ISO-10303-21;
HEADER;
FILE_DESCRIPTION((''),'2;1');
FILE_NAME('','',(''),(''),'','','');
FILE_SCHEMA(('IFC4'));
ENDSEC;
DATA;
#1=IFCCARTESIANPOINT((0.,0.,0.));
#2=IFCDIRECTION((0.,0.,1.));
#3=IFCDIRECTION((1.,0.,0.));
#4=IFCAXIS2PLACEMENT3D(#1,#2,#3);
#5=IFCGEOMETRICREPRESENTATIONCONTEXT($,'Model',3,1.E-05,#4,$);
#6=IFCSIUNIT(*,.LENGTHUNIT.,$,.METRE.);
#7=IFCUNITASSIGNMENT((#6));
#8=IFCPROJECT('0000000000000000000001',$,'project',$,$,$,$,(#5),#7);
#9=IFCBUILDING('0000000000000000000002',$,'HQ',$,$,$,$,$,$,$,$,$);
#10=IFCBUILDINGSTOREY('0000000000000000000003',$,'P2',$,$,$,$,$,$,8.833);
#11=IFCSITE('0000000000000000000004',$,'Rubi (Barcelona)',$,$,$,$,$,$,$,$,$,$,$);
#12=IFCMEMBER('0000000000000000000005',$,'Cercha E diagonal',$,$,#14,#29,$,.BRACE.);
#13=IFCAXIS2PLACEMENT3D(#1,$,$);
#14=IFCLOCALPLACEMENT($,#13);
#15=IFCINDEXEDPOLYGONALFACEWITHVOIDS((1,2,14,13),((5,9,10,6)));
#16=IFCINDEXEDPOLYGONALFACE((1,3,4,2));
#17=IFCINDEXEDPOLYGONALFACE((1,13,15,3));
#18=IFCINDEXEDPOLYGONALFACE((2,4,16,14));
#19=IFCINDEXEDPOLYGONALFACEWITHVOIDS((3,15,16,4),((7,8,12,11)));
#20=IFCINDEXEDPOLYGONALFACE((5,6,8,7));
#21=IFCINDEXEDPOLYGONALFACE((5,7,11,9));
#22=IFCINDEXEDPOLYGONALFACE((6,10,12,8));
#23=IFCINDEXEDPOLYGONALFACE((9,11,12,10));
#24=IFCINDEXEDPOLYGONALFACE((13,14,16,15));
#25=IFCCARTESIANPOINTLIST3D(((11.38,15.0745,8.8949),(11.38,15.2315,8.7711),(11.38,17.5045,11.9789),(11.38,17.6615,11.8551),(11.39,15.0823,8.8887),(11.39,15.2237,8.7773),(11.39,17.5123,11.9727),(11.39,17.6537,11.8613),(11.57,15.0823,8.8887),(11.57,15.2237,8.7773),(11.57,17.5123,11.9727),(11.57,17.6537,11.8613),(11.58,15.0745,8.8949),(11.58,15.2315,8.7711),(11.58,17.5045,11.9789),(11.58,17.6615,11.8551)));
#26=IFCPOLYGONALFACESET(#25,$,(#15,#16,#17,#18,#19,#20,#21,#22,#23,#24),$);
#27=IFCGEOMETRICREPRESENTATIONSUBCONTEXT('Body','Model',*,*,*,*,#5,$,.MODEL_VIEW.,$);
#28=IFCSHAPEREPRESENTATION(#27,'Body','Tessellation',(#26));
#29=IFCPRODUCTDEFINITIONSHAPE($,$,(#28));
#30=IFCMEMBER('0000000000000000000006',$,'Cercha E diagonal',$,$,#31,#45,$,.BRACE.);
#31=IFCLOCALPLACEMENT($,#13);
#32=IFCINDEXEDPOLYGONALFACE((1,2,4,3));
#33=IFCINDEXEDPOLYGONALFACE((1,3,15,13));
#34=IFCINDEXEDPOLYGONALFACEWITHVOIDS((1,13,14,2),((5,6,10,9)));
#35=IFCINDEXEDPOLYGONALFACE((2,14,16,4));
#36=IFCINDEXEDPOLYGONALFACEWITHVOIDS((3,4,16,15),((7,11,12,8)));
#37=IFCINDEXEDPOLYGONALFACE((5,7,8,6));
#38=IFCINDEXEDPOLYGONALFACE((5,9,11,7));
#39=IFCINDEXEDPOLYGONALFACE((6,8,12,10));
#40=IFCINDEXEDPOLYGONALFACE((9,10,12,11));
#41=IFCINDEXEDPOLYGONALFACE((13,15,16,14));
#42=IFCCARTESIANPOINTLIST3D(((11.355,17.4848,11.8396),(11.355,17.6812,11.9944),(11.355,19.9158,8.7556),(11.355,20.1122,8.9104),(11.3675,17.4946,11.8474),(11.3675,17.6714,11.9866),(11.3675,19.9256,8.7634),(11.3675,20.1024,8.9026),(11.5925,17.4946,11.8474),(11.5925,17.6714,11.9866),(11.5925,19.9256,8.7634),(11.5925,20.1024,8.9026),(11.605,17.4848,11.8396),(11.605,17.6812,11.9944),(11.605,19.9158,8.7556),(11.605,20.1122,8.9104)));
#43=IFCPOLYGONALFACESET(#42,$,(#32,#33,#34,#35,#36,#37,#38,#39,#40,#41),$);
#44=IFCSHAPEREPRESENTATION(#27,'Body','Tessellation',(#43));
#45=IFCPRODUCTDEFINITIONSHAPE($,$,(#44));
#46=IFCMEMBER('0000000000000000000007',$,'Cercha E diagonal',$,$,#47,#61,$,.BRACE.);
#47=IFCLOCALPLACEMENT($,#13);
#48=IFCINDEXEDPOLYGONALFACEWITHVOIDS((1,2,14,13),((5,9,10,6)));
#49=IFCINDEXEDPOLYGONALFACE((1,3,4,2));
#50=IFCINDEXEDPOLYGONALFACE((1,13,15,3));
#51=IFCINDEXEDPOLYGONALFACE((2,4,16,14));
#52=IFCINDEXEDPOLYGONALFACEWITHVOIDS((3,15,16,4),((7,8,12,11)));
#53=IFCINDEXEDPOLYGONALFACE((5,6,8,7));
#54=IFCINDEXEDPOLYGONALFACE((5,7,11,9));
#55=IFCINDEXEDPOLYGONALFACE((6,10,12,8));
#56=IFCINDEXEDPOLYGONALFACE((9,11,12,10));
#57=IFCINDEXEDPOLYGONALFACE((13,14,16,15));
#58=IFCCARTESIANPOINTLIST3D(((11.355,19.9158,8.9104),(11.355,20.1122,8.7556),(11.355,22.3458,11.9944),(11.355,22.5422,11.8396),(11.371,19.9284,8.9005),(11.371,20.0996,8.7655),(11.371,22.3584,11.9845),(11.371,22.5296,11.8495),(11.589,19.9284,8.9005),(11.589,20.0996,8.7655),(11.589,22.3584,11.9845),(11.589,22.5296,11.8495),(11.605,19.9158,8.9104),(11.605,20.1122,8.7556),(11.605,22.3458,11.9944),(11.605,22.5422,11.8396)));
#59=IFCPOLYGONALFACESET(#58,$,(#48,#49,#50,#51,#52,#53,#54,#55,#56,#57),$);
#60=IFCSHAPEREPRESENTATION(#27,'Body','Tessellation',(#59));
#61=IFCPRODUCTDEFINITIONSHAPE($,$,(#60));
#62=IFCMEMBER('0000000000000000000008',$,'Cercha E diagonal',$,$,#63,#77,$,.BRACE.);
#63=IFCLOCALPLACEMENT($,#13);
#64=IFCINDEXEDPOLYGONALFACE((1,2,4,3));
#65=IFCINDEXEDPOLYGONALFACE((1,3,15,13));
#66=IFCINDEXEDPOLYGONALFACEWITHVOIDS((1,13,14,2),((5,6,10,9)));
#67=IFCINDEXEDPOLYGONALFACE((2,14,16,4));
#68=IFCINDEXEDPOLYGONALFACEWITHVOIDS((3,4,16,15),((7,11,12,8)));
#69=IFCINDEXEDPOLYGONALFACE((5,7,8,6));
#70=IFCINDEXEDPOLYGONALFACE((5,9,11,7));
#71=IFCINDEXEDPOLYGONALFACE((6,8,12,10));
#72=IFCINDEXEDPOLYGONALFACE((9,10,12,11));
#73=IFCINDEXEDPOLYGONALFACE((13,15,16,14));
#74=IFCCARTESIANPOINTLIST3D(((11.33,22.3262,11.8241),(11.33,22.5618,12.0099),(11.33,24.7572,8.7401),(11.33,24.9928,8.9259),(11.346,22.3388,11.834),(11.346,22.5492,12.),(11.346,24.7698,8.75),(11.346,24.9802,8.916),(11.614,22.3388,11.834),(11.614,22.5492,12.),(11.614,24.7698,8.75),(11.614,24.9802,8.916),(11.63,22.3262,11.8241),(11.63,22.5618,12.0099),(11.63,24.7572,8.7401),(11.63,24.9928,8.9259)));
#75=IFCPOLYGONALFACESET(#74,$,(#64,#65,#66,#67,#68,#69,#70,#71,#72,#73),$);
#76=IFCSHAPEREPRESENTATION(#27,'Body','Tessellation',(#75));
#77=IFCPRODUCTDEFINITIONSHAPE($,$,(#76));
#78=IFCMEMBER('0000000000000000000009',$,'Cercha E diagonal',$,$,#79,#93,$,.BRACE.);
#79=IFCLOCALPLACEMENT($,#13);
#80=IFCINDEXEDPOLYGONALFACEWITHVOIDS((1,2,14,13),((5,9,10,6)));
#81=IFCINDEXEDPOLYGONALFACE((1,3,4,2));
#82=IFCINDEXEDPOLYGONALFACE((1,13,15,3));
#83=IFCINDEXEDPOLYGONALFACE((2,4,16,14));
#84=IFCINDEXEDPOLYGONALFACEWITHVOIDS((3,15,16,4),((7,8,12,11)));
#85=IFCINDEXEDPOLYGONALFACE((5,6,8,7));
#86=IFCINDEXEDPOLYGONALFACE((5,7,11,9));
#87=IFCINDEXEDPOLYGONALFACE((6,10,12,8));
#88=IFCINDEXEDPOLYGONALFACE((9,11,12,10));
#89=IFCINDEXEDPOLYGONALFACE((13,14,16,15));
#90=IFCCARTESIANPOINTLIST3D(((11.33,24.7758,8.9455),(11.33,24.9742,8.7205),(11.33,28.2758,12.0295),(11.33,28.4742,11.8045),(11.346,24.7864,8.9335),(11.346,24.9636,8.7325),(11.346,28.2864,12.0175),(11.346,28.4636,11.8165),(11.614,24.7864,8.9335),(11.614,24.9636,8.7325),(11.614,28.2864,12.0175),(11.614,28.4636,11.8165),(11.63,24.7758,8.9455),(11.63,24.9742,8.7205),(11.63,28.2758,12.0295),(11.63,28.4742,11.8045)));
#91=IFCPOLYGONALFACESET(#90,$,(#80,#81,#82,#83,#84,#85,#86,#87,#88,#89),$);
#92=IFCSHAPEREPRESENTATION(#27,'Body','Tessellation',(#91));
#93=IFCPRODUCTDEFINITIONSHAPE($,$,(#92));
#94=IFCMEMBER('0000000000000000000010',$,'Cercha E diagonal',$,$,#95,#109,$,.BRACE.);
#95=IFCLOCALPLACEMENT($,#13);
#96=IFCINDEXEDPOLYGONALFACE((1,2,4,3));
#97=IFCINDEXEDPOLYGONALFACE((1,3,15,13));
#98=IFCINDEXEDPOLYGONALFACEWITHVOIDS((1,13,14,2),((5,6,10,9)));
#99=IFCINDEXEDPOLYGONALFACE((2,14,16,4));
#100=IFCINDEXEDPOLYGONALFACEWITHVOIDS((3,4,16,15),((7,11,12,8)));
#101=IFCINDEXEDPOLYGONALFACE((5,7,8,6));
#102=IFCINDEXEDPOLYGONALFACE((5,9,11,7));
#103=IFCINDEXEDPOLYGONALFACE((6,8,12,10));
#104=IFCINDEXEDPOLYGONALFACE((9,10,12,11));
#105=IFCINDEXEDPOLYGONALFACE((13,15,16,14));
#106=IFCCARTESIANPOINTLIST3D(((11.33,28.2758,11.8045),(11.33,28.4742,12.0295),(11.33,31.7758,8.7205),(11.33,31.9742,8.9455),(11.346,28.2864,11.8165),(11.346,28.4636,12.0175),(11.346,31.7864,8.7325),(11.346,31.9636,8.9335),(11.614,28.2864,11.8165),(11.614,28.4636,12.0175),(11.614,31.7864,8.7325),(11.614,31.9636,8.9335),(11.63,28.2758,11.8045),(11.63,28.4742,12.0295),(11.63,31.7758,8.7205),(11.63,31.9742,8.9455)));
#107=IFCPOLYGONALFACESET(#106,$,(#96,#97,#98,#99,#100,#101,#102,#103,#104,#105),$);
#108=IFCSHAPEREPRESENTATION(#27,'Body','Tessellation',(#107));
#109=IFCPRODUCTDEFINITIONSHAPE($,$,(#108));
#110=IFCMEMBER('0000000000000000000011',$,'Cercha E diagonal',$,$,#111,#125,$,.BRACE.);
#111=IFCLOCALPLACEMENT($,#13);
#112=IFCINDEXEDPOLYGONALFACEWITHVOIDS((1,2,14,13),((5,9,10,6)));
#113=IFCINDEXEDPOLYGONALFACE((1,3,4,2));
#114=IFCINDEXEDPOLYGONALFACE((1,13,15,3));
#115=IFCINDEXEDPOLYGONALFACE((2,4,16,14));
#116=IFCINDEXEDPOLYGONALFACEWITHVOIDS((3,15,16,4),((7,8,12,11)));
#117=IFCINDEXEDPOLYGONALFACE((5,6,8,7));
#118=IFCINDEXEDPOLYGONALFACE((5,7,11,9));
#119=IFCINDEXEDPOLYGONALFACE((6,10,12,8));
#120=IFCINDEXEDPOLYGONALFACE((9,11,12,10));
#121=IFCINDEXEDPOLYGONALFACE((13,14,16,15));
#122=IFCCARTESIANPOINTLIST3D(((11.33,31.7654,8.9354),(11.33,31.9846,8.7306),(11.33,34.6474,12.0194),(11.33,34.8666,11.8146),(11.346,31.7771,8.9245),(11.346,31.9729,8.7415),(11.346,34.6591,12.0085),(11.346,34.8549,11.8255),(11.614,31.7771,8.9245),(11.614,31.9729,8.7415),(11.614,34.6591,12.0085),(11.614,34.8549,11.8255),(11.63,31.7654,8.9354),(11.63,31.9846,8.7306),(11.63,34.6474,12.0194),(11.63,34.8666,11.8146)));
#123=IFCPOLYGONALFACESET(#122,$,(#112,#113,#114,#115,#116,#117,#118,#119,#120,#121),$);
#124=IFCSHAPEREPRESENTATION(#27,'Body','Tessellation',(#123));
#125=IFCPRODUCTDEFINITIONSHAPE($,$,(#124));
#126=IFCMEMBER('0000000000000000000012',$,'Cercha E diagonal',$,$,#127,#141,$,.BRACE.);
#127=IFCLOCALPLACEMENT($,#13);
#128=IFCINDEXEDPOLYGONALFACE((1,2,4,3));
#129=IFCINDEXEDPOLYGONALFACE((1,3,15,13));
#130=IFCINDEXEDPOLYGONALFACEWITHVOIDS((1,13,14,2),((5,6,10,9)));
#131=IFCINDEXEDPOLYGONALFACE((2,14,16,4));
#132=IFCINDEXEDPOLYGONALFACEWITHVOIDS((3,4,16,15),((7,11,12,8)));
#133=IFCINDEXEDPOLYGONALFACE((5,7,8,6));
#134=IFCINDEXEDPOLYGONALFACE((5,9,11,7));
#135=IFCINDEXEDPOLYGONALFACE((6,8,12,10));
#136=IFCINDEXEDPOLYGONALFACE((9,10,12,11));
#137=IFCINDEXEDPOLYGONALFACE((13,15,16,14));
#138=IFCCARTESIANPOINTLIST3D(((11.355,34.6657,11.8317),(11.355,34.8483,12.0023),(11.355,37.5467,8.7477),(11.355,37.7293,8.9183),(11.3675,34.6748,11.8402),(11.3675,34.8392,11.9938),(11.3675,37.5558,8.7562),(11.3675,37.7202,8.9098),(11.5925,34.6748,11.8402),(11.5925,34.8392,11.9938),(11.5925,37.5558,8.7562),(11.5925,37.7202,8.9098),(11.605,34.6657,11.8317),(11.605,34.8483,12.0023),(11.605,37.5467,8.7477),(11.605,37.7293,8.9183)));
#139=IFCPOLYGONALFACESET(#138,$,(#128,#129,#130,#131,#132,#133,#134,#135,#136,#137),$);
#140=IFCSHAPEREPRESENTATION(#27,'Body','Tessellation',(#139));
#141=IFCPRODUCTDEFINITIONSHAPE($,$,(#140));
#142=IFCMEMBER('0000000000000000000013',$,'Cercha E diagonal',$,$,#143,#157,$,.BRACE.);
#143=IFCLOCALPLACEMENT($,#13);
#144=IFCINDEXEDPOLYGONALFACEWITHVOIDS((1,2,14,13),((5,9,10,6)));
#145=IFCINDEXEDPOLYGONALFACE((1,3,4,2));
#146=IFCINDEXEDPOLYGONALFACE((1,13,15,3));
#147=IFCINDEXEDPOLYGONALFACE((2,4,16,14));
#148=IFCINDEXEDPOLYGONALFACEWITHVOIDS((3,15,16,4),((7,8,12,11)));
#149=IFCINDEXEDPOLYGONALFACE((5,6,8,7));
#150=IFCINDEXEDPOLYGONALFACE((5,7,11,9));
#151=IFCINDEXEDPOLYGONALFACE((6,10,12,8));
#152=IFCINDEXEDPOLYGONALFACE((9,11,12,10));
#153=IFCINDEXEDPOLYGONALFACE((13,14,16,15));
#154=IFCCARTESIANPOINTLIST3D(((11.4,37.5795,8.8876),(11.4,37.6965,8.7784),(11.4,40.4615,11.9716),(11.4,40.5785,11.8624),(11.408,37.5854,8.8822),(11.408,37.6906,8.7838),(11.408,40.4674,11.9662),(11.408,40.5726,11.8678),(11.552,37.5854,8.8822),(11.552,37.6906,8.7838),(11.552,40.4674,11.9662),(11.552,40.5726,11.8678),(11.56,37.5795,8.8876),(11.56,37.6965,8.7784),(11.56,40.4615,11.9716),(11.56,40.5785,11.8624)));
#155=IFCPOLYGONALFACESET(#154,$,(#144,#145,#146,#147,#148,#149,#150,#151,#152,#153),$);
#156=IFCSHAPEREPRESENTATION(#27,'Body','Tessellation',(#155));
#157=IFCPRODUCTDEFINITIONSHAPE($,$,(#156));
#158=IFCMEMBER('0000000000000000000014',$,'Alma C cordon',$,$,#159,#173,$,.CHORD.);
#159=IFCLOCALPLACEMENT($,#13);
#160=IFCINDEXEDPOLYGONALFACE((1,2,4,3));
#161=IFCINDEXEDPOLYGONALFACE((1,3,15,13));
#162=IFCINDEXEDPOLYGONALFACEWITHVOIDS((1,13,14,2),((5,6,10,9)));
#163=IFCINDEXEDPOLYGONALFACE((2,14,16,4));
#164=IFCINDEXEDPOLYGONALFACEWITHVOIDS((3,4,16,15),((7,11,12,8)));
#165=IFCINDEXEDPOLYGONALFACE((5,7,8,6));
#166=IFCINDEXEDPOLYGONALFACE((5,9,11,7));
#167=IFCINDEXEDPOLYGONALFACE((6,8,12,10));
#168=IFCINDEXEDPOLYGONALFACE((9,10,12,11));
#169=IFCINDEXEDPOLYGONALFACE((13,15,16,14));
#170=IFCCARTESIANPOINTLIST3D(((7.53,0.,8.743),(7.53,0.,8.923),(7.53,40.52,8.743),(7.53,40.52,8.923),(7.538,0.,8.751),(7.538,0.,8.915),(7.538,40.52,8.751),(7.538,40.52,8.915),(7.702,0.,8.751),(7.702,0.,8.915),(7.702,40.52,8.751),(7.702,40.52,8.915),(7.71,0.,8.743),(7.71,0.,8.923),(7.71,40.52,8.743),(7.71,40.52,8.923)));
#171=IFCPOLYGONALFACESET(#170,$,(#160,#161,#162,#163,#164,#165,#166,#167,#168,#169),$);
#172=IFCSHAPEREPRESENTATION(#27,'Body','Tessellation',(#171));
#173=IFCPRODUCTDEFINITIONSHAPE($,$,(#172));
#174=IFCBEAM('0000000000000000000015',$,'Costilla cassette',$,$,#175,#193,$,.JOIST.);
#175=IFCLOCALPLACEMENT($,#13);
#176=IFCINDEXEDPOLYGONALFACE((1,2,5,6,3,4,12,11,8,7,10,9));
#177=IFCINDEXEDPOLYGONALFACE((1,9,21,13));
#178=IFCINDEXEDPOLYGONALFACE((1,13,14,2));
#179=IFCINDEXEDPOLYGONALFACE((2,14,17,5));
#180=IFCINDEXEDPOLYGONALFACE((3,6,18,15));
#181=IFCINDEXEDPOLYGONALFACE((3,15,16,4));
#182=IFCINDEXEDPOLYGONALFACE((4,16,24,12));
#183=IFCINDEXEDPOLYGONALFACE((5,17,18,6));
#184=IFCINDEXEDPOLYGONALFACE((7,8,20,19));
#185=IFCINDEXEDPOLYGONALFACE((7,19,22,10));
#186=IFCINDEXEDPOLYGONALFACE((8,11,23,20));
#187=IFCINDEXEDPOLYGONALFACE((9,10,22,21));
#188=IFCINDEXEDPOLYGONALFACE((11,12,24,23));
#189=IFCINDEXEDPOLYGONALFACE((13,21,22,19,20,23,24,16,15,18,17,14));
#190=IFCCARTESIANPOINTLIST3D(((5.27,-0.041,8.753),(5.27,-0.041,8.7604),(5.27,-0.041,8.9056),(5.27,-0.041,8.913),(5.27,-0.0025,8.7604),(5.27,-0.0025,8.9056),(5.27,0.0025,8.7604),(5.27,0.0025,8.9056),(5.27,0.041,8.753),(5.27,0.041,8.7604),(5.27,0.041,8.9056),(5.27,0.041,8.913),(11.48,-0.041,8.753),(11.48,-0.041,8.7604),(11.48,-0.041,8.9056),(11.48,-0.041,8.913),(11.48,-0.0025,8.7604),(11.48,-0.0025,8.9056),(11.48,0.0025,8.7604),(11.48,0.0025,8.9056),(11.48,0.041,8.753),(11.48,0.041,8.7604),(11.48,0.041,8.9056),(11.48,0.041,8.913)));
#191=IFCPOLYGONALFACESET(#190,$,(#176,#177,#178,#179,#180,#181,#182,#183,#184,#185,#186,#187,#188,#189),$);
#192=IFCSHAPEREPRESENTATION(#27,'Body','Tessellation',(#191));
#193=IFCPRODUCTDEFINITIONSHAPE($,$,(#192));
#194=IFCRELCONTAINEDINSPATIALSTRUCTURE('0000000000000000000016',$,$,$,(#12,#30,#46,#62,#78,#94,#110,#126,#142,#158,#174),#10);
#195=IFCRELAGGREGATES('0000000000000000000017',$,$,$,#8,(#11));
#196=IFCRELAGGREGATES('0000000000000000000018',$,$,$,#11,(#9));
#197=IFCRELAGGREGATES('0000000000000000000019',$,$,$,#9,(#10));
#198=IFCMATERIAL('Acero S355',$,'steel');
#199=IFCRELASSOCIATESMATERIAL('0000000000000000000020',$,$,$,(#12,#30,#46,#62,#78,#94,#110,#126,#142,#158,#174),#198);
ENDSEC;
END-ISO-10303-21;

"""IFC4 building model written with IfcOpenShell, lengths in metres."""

from ifc_helpers import new_model, si_unit, frame, origin_with_axes, place, context, subcontext, project, spatial, hollow_rectangle, i_section, extrude, material, element, save


model = new_model("IFC4")

# Units and contexts
model_context = context("Model", 3, precision=1e-05, world=origin_with_axes())
body_context = subcontext(model_context, "Body", "Model", "MODEL_VIEW")
ifc_project = project(units=[si_unit("LENGTHUNIT", "METRE")], contexts=[model_context])

# Site, building, storey
site = spatial("IfcSite", under=ifc_project, Name="Rubi (Barcelona)")
building = spatial("IfcBuilding", under=site, Name="HQ")
storey = spatial("IfcBuildingStorey", under=building, Name="P2", Elevation=8.833)

# Members
ifc_material = material(Name="Acero S355", Category="steel")
member_1_placement = place(None, origin_with_axes())
element("IfcMember", 1, at=member_1_placement, inside=storey, material=ifc_material, Name="Cercha E diagonal", PredefinedType="BRACE", context=body_context, shape_type="SweptSolid", body=[
    extrude(hollow_rectangle(XDim=0.2, YDim=0.2, WallThickness=0.01), frame((11.48, 15.153, 8.833), z_axis=(0.0, 0.618901, 0.785469), x_axis=(-1.0, 0.0, 0.0)), (0.0, 0.0, 1.0), 3.9263),
])
member_2_placement = place(None, origin_with_axes())
element("IfcMember", 2, at=member_2_placement, inside=storey, material=ifc_material, Name="Cercha E diagonal", PredefinedType="BRACE", context=body_context, shape_type="SweptSolid", body=[
    extrude(hollow_rectangle(XDim=0.25, YDim=0.25, WallThickness=0.0125), frame((11.48, 20.014, 8.833), z_axis=(0.0, -0.619058, 0.785345), x_axis=(1.0, 0.0, 0.0)), (0.0, 0.0, 1.0), 3.9269),
])
member_3_placement = place(None, origin_with_axes())
element("IfcMember", 3, at=member_3_placement, inside=storey, material=ifc_material, Name="Cercha E diagonal", PredefinedType="BRACE", context=body_context, shape_type="SweptSolid", body=[
    extrude(hollow_rectangle(XDim=0.25, YDim=0.25, WallThickness=0.016), frame((11.48, 20.014, 8.833), z_axis=(0.0, 0.618901, 0.785469), x_axis=(-1.0, 0.0, 0.0)), (0.0, 0.0, 1.0), 3.9263),
])
member_4_placement = place(None, origin_with_axes())
element("IfcMember", 4, at=member_4_placement, inside=storey, material=ifc_material, Name="Cercha E diagonal", PredefinedType="BRACE", context=body_context, shape_type="SweptSolid", body=[
    extrude(hollow_rectangle(XDim=0.3, YDim=0.3, WallThickness=0.016), frame((11.48, 24.875, 8.833), z_axis=(0.0, -0.619058, 0.785345), x_axis=(1.0, 0.0, 0.0)), (0.0, 0.0, 1.0), 3.9269),
])
member_5_placement = place(None, origin_with_axes())
element("IfcMember", 5, at=member_5_placement, inside=storey, material=ifc_material, Name="Cercha E diagonal", PredefinedType="BRACE", context=body_context, shape_type="SweptSolid", body=[
    extrude(hollow_rectangle(XDim=0.3, YDim=0.3, WallThickness=0.016), frame((11.48, 24.875, 8.833), z_axis=(0.0, 0.750288, 0.661111), x_axis=(-1.0, 0.0, 0.0)), (0.0, 0.0, 1.0), 4.6649),
])
member_6_placement = place(None, origin_with_axes())
element("IfcMember", 6, at=member_6_placement, inside=storey, material=ifc_material, Name="Cercha E diagonal", PredefinedType="BRACE", context=body_context, shape_type="SweptSolid", body=[
    extrude(hollow_rectangle(XDim=0.3, YDim=0.3, WallThickness=0.016), frame((11.48, 31.875, 8.833), z_axis=(0.0, -0.750288, 0.661111), x_axis=(1.0, 0.0, 0.0)), (0.0, 0.0, 1.0), 4.6649),
])
member_7_placement = place(None, origin_with_axes())
element("IfcMember", 7, at=member_7_placement, inside=storey, material=ifc_material, Name="Cercha E diagonal", PredefinedType="BRACE", context=body_context, shape_type="SweptSolid", body=[
    extrude(hollow_rectangle(XDim=0.3, YDim=0.3, WallThickness=0.016), frame((11.48, 31.875, 8.833), z_axis=(0.0, 0.682774, 0.73063), x_axis=(-1.0, 0.0, 0.0)), (0.0, 0.0, 1.0), 4.221),
])
member_8_placement = place(None, origin_with_axes())
element("IfcMember", 8, at=member_8_placement, inside=storey, material=ifc_material, Name="Cercha E diagonal", PredefinedType="BRACE", context=body_context, shape_type="SweptSolid", body=[
    extrude(hollow_rectangle(XDim=0.25, YDim=0.25, WallThickness=0.0125), frame((11.48, 37.638, 8.833), z_axis=(0.0, -0.682647, 0.730748), x_axis=(1.0, 0.0, 0.0)), (0.0, 0.0, 1.0), 4.2203),
])
member_9_placement = place(None, origin_with_axes())
element("IfcMember", 9, at=member_9_placement, inside=storey, material=ifc_material, Name="Cercha E diagonal", PredefinedType="BRACE", context=body_context, shape_type="SweptSolid", body=[
    extrude(hollow_rectangle(XDim=0.16, YDim=0.16, WallThickness=0.008), frame((11.48, 37.638, 8.833), z_axis=(0.0, 0.682774, 0.73063), x_axis=(-1.0, 0.0, 0.0)), (0.0, 0.0, 1.0), 4.221),
])
member_10_placement = place(None, origin_with_axes())
element("IfcMember", 10, at=member_10_placement, inside=storey, material=ifc_material, Name="Alma C cordon", PredefinedType="CHORD", context=body_context, shape_type="SweptSolid", body=[
    extrude(hollow_rectangle(XDim=0.18, YDim=0.18, WallThickness=0.008), frame((7.62, 0.0, 8.833), z_axis=(0.0, 1.0, 0.0), x_axis=(-1.0, 0.0, 0.0)), (0.0, 0.0, 1.0), 40.52),
])

# Beam
beam_1_placement = place(None, origin_with_axes())
element("IfcBeam", 11, at=beam_1_placement, inside=storey, material=ifc_material, Name="Costilla cassette", PredefinedType="JOIST", context=body_context, shape_type="SweptSolid", body=[
    extrude(i_section(OverallWidth=0.082, OverallDepth=0.16, WebThickness=0.005, FlangeThickness=0.0074), frame((5.27, 0.0, 8.833), z_axis=(1.0, 0.0, 0.0), x_axis=(0.0, 1.0, 0.0)), (0.0, 0.0, 1.0), 6.21),
])

save(model, "model.ifc")
